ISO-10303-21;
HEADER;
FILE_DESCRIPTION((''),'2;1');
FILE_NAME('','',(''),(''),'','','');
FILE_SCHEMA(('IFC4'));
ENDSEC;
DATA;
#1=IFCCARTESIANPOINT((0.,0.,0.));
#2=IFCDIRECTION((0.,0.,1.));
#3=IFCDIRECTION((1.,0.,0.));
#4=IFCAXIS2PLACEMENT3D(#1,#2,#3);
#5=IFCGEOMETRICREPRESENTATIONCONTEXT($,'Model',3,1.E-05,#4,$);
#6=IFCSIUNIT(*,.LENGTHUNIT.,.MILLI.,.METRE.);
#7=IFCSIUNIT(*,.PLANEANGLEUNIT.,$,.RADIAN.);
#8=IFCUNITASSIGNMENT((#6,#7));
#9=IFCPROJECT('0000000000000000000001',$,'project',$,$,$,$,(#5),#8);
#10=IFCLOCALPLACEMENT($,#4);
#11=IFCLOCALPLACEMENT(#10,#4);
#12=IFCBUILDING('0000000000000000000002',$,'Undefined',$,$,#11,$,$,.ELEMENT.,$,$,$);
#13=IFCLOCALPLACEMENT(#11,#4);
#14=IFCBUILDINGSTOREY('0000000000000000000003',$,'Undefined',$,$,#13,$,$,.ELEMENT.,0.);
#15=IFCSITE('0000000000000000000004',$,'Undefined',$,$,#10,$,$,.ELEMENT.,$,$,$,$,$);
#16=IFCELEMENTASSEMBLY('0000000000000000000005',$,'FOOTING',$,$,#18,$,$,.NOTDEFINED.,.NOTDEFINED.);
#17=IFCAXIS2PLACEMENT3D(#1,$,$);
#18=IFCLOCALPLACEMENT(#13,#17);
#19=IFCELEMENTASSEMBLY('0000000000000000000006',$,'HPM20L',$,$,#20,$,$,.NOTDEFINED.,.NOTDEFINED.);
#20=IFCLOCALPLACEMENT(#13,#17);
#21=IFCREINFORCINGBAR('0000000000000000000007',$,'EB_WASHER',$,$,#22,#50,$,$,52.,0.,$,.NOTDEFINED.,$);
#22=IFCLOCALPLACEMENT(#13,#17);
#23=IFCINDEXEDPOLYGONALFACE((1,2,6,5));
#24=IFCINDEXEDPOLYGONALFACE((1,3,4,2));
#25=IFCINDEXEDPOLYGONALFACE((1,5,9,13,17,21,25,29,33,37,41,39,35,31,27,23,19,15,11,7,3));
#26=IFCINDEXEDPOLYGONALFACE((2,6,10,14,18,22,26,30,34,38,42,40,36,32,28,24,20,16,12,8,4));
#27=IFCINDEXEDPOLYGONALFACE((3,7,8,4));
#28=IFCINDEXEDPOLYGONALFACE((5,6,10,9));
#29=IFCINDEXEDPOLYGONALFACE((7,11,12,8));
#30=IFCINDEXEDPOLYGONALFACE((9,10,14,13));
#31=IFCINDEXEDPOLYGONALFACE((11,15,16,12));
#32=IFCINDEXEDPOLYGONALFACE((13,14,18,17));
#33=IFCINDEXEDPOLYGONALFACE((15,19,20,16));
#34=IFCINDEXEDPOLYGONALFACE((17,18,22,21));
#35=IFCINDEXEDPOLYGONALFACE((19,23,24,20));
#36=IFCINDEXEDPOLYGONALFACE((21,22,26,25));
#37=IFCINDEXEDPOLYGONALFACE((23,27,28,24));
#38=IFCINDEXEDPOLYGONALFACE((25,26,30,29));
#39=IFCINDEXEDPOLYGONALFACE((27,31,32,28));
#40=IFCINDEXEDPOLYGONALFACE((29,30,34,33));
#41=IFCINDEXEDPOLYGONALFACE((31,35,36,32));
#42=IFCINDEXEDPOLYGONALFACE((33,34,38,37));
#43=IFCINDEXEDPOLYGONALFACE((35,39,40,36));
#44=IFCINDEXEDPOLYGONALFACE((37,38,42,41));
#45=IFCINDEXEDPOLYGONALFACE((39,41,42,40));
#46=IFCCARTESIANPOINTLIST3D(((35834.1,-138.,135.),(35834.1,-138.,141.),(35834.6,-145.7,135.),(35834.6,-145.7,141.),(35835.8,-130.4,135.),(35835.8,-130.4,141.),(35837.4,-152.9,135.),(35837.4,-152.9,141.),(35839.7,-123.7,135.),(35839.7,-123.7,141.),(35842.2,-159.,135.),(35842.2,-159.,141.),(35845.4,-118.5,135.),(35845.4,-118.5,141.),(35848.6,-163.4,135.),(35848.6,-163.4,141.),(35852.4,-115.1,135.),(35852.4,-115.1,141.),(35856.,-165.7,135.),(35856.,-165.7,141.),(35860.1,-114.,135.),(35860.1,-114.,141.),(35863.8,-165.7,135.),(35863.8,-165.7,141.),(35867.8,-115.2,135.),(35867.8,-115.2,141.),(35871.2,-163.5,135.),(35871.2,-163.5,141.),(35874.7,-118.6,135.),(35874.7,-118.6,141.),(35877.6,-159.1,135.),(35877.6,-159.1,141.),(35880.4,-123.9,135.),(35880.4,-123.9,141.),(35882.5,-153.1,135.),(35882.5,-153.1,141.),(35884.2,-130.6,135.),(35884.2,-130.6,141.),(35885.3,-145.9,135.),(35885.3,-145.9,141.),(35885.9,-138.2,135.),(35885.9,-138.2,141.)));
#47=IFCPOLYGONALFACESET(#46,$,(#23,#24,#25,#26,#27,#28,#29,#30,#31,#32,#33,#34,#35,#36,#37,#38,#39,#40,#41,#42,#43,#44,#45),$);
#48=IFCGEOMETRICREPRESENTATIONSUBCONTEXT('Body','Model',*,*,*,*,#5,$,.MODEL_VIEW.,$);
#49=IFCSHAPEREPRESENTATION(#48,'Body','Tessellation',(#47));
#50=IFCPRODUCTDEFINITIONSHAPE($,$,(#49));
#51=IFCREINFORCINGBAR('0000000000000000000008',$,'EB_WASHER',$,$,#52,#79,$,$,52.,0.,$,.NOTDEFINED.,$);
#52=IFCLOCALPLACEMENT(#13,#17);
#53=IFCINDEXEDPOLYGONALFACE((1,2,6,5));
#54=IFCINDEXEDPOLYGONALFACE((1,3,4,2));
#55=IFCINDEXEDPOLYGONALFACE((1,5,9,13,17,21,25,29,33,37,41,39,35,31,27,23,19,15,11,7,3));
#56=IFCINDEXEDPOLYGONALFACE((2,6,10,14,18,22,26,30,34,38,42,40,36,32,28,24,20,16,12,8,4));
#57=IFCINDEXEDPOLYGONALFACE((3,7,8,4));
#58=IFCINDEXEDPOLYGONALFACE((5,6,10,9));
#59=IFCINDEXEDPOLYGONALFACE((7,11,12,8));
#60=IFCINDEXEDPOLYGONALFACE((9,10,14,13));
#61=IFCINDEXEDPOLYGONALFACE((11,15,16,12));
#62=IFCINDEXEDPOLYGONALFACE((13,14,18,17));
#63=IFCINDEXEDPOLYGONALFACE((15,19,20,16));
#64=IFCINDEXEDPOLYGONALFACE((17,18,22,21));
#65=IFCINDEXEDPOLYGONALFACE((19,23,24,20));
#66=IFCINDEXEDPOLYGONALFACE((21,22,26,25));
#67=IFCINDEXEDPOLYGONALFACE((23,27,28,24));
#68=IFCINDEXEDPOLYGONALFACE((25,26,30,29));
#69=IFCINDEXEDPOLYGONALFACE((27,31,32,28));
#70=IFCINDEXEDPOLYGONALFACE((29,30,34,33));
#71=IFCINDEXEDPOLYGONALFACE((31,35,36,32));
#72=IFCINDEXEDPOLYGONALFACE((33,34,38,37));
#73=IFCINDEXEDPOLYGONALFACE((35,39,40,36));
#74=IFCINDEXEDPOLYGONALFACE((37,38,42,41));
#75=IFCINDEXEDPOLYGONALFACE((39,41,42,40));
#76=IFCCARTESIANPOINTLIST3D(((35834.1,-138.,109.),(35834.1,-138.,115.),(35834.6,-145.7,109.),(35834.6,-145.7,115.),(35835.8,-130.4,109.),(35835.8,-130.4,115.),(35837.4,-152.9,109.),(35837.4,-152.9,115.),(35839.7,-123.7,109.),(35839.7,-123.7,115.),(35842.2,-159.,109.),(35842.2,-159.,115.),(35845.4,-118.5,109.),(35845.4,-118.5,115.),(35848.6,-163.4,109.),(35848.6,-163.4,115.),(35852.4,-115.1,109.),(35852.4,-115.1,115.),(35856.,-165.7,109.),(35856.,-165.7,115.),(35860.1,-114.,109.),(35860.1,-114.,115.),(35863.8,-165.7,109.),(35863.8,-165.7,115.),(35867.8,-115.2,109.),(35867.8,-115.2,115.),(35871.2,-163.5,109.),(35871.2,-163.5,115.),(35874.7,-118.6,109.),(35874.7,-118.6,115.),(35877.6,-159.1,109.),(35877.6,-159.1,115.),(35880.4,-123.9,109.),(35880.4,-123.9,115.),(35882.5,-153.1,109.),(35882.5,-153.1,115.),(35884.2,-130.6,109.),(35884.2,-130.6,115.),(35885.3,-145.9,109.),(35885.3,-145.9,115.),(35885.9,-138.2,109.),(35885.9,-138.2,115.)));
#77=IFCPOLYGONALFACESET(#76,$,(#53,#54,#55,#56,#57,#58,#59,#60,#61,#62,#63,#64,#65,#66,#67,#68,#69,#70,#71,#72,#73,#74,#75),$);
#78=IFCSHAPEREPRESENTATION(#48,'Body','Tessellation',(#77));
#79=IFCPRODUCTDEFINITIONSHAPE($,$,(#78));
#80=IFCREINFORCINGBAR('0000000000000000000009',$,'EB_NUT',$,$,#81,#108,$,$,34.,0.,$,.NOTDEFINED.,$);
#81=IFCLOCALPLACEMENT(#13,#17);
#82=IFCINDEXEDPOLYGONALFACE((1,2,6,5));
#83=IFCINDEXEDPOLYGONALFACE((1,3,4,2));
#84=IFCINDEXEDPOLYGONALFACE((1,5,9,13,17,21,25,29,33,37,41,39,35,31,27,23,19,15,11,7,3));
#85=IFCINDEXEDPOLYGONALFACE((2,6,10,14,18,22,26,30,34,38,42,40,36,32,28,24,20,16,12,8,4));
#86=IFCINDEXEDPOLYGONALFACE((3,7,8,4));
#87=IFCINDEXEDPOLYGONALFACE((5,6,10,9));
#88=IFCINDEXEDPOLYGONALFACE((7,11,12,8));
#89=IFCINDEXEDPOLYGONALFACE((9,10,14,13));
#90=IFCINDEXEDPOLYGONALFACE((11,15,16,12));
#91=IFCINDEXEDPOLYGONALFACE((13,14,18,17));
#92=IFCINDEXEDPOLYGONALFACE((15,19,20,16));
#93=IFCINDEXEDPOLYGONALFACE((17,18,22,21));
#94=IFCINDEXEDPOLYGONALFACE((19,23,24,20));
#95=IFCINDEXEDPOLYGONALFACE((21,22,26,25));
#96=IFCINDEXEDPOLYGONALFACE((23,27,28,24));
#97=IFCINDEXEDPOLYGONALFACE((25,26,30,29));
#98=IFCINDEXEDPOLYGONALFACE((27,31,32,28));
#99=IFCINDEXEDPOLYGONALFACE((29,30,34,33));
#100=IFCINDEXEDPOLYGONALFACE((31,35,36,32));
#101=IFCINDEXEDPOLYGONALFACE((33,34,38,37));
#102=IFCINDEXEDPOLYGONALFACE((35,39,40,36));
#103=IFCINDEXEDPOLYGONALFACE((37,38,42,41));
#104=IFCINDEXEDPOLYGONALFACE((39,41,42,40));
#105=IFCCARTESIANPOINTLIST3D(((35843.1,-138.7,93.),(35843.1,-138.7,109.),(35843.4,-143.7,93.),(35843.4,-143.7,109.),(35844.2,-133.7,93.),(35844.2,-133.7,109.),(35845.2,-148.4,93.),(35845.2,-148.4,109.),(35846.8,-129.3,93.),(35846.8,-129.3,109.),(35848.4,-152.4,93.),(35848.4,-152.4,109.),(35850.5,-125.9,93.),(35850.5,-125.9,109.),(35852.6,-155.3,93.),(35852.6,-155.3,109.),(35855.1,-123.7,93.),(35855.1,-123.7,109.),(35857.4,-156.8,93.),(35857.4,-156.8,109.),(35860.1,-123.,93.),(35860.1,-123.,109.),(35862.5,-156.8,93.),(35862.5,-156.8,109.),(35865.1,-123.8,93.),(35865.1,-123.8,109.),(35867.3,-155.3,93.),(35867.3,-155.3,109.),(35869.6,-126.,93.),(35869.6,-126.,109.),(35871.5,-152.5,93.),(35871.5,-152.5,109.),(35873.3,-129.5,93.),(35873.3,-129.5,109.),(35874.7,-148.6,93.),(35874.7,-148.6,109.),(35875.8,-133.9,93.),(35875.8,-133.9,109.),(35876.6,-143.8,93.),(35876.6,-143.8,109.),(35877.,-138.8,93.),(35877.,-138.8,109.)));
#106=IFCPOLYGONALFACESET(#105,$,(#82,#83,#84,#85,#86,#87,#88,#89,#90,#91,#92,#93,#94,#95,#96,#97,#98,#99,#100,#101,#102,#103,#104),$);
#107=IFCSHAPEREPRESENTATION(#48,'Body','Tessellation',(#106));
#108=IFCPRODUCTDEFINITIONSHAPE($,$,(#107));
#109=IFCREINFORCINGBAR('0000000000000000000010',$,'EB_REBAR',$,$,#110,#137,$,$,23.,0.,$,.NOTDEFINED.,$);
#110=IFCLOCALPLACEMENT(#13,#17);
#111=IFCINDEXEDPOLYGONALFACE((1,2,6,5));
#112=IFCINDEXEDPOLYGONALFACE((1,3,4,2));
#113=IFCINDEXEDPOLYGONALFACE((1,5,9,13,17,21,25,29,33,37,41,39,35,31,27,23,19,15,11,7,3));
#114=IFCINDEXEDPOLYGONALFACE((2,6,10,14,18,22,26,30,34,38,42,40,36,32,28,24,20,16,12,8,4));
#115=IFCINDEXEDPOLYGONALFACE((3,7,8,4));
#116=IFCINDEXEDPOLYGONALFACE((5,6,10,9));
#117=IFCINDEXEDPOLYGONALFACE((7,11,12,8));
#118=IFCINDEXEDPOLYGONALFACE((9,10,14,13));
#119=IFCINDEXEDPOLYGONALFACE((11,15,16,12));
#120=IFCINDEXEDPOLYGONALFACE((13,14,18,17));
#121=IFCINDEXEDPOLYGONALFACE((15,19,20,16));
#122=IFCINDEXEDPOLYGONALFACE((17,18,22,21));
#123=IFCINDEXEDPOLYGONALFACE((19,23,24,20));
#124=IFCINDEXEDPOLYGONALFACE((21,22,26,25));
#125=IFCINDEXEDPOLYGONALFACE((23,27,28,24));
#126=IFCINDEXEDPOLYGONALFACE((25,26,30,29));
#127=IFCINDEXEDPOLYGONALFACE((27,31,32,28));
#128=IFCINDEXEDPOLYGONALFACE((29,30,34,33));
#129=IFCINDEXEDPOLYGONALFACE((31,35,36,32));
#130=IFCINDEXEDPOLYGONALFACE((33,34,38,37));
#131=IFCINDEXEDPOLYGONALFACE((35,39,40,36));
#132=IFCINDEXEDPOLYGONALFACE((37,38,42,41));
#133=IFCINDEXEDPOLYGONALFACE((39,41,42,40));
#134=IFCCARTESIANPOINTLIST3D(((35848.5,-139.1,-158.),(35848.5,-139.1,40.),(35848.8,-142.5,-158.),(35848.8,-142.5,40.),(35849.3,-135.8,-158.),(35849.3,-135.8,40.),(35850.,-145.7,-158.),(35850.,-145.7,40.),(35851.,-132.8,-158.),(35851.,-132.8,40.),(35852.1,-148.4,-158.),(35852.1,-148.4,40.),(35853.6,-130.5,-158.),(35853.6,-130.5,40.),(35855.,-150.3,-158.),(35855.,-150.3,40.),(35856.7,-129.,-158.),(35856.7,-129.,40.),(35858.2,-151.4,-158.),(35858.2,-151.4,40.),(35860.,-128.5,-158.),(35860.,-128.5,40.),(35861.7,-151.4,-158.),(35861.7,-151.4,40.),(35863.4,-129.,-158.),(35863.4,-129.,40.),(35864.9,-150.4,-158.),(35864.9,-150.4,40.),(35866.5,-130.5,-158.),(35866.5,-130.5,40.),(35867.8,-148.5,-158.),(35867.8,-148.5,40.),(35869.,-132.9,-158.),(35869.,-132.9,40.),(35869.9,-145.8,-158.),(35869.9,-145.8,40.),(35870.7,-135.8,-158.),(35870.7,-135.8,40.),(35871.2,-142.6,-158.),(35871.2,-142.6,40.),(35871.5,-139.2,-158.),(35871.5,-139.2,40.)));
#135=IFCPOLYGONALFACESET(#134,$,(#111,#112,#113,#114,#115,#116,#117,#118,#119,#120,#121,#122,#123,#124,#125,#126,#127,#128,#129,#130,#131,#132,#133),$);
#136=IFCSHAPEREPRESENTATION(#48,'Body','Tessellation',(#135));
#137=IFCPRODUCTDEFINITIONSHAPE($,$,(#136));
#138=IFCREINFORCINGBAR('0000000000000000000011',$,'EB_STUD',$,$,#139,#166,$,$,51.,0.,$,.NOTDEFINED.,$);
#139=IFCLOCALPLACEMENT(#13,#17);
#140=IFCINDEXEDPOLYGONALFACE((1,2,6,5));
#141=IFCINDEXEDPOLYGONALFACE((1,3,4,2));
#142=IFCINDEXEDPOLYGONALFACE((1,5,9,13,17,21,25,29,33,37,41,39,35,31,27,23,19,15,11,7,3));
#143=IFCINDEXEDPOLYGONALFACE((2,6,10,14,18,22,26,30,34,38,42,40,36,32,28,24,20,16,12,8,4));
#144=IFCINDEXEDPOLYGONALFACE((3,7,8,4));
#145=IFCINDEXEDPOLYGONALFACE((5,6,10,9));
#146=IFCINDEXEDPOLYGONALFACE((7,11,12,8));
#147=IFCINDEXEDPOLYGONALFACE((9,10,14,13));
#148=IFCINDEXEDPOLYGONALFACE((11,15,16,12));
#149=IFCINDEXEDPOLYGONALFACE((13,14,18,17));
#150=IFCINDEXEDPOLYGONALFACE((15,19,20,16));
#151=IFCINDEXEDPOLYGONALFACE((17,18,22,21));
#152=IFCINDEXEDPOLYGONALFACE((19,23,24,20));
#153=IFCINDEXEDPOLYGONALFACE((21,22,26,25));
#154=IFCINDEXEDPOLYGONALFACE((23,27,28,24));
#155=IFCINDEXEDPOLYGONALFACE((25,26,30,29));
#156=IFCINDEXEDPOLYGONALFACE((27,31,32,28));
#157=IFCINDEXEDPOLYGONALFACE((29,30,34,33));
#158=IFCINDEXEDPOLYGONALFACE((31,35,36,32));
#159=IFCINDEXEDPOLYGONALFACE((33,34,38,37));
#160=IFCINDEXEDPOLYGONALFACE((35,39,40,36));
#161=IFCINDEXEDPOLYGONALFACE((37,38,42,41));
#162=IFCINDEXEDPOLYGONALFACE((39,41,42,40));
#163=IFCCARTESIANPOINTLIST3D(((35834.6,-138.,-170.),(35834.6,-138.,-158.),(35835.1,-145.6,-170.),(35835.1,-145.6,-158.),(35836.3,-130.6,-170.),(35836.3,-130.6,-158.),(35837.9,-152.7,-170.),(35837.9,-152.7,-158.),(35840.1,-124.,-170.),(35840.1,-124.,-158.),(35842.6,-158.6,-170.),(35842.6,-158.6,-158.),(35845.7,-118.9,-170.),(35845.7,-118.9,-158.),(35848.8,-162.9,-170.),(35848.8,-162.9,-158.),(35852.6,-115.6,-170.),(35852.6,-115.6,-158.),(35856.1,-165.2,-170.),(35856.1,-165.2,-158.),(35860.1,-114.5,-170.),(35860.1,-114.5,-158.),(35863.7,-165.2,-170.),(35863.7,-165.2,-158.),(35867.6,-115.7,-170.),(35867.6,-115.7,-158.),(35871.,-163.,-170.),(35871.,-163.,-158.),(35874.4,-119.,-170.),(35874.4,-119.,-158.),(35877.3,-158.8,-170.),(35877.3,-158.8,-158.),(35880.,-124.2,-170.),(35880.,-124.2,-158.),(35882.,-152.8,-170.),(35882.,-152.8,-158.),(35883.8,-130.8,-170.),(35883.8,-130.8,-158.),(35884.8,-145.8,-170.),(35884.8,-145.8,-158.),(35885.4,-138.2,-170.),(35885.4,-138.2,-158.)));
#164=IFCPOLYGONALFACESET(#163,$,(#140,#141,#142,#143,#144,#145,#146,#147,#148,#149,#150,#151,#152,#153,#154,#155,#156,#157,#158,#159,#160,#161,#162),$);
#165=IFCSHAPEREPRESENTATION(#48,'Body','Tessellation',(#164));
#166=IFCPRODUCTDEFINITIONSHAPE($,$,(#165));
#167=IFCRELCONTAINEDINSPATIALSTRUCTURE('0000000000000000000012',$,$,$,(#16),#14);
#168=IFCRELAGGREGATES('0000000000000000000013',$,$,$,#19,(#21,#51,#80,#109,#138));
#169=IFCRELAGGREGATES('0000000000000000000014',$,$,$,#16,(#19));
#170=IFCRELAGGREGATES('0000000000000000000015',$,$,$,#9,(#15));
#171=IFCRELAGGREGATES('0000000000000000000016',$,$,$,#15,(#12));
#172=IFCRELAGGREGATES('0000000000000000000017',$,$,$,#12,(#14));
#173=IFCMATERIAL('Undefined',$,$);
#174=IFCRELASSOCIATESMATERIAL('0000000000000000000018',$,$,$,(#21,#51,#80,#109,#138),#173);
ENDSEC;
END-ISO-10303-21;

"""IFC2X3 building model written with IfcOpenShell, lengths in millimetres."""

from ifc_helpers import new_model, entity, si_unit, frame, origin_with_axes, place, context, subcontext, project, spatial, source, transform, mapped, material, element, aggregate, save


model = new_model("IFC2X3")

# Units and contexts
model_context = context("Model", 3, precision=1e-05, world=origin_with_axes())
body_context = subcontext(model_context, "Body", "Model", "MODEL_VIEW")
ifc_project = project(units=[si_unit("LENGTHUNIT", "METRE", prefix="MILLI"), si_unit("PLANEANGLEUNIT", "RADIAN")], contexts=[model_context])

# Site, building, storey
site_placement = place(None, origin_with_axes())
site = spatial("IfcSite", under=ifc_project, at=site_placement, Name="Undefined", CompositionType="ELEMENT")
building_placement = place(site_placement, origin_with_axes())
building = spatial("IfcBuilding", under=site, at=building_placement, Name="Undefined", CompositionType="ELEMENT")
storey_placement = place(building_placement, origin_with_axes())
storey = spatial("IfcBuildingStorey", under=building, at=storey_placement, Name="Undefined", CompositionType="ELEMENT", Elevation=0.0)

# Element assembly
assembly_1_placement = place(storey_placement, origin_with_axes())
assembly_1 = element("IfcElementAssembly", 1, at=assembly_1_placement, inside=storey, Name="FOOTING", AssemblyPlace="NOTDEFINED", PredefinedType="NOTDEFINED")

# Shared definitions
ifc_material_1 = material(Name="Undefined")

# Element assembly, reinforcing bars
assembly_2_placement = place(assembly_1_placement, origin_with_axes())
assembly_2 = element("IfcElementAssembly", 2, at=assembly_2_placement, Name="HPM20L", AssemblyPlace="NOTDEFINED", PredefinedType="NOTDEFINED")
shared_shape_1 = source(origin_with_axes(), body_context, "Body", "AdvancedSweptSolid", [
    entity("IfcSweptDiskSolid", entity("IfcTrimmedCurve", entity("IfcLine", entity("IfcCartesianPoint", [0.0, 0.0, 0.0]), entity("IfcVector", entity("IfcDirection", [1.0, 0.0, 0.0]), 1.0)), [entity("IfcParameterValue", 0.0)], [entity("IfcParameterValue", 6.0)], True, "PARAMETER"), 26.0, None, 0.0, 6.0),
])
reinforcing_bar_1_placement = place(assembly_2_placement, frame((35860.0, -140.0, 141.0), z_axis=(0.003904, 0.999992, 0.0), x_axis=(0.0, 0.0, -1.0)))
reinforcing_bar_1 = element("IfcReinforcingBar", 3, at=reinforcing_bar_1_placement, material=ifc_material_1, Name="EB_WASHER", BarRole="NOTDEFINED", CrossSectionArea=0.0, NominalDiameter=52.0, context=body_context, shape_type="MappedRepresentation", body=[
    mapped(shared_shape_1, transform((0.0, 0.0, 0.0))),
])
shared_shape_2 = source(origin_with_axes(), body_context, "Body", "AdvancedSweptSolid", [
    entity("IfcSweptDiskSolid", entity("IfcTrimmedCurve", entity("IfcLine", entity("IfcCartesianPoint", [0.0, 0.0, 0.0]), entity("IfcVector", entity("IfcDirection", [1.0, 0.0, 0.0]), 1.0)), [entity("IfcParameterValue", 0.0)], [entity("IfcParameterValue", 6.0)], True, "PARAMETER"), 26.0, None, 0.0, 6.0),
])
reinforcing_bar_2_placement = place(assembly_2_placement, frame((35860.0, -140.0, 115.0), z_axis=(0.003904, 0.999992, 0.0), x_axis=(0.0, 0.0, -1.0)))
reinforcing_bar_2 = element("IfcReinforcingBar", 4, at=reinforcing_bar_2_placement, material=ifc_material_1, Name="EB_WASHER", BarRole="NOTDEFINED", CrossSectionArea=0.0, NominalDiameter=52.0, context=body_context, shape_type="MappedRepresentation", body=[
    mapped(shared_shape_2, transform((0.0, 0.0, 0.0))),
])
shared_shape_3 = source(origin_with_axes(), body_context, "Body", "AdvancedSweptSolid", [
    entity("IfcSweptDiskSolid", entity("IfcTrimmedCurve", entity("IfcLine", entity("IfcCartesianPoint", [0.0, 0.0, 0.0]), entity("IfcVector", entity("IfcDirection", [1.0, 0.0, 0.0]), 1.0)), [entity("IfcParameterValue", 0.0)], [entity("IfcParameterValue", 16.0)], True, "PARAMETER"), 17.0, None, 0.0, 16.0),
])
reinforcing_bar_3_placement = place(assembly_2_placement, frame((35860.0, -140.0, 109.0), z_axis=(0.003904, 0.999992, 0.0), x_axis=(0.0, 0.0, -1.0)))
reinforcing_bar_3 = element("IfcReinforcingBar", 5, at=reinforcing_bar_3_placement, material=ifc_material_1, Name="EB_NUT", BarRole="NOTDEFINED", CrossSectionArea=0.0, NominalDiameter=34.0, context=body_context, shape_type="MappedRepresentation", body=[
    mapped(shared_shape_3, transform((0.0, 0.0, 0.0))),
])
shared_shape_4 = source(origin_with_axes(), body_context, "Body", "AdvancedSweptSolid", [
    entity("IfcSweptDiskSolid", entity("IfcTrimmedCurve", entity("IfcLine", entity("IfcCartesianPoint", [0.0, 0.0, 0.0]), entity("IfcVector", entity("IfcDirection", [1.0, 0.0, 0.0]), 1.0)), [entity("IfcParameterValue", 0.0)], [entity("IfcParameterValue", 198.0)], True, "PARAMETER"), 11.5, None, 0.0, 198.0),
])
reinforcing_bar_4_placement = place(assembly_2_placement, frame((35860.0, -140.0, 40.0), z_axis=(0.003904, 0.999992, 0.0), x_axis=(0.0, 0.0, -1.0)))
reinforcing_bar_4 = element("IfcReinforcingBar", 6, at=reinforcing_bar_4_placement, material=ifc_material_1, Name="EB_REBAR", BarRole="NOTDEFINED", CrossSectionArea=0.0, NominalDiameter=23.0, context=body_context, shape_type="MappedRepresentation", body=[
    mapped(shared_shape_4, transform((0.0, 0.0, 0.0))),
])
shared_shape_5 = source(origin_with_axes(), body_context, "Body", "AdvancedSweptSolid", [
    entity("IfcSweptDiskSolid", entity("IfcTrimmedCurve", entity("IfcLine", entity("IfcCartesianPoint", [0.0, 0.0, 0.0]), entity("IfcVector", entity("IfcDirection", [1.0, 0.0, 0.0]), 1.0)), [entity("IfcParameterValue", 0.0)], [entity("IfcParameterValue", 12.0)], True, "PARAMETER"), 25.5, None, 0.0, 12.0),
])
reinforcing_bar_5_placement = place(assembly_2_placement, frame((35860.0, -140.0, -158.0), z_axis=(0.003904, 0.999992, 0.0), x_axis=(0.0, 0.0, -1.0)))
reinforcing_bar_5 = element("IfcReinforcingBar", 7, at=reinforcing_bar_5_placement, material=ifc_material_1, Name="EB_STUD", BarRole="NOTDEFINED", CrossSectionArea=0.0, NominalDiameter=51.0, context=body_context, shape_type="MappedRepresentation", body=[
    mapped(shared_shape_5, transform((0.0, 0.0, 0.0))),
])
aggregate(assembly_2, [reinforcing_bar_1, reinforcing_bar_2, reinforcing_bar_3, reinforcing_bar_4, reinforcing_bar_5])

aggregate(assembly_1, [assembly_2])

save(model, "model.ifc")
